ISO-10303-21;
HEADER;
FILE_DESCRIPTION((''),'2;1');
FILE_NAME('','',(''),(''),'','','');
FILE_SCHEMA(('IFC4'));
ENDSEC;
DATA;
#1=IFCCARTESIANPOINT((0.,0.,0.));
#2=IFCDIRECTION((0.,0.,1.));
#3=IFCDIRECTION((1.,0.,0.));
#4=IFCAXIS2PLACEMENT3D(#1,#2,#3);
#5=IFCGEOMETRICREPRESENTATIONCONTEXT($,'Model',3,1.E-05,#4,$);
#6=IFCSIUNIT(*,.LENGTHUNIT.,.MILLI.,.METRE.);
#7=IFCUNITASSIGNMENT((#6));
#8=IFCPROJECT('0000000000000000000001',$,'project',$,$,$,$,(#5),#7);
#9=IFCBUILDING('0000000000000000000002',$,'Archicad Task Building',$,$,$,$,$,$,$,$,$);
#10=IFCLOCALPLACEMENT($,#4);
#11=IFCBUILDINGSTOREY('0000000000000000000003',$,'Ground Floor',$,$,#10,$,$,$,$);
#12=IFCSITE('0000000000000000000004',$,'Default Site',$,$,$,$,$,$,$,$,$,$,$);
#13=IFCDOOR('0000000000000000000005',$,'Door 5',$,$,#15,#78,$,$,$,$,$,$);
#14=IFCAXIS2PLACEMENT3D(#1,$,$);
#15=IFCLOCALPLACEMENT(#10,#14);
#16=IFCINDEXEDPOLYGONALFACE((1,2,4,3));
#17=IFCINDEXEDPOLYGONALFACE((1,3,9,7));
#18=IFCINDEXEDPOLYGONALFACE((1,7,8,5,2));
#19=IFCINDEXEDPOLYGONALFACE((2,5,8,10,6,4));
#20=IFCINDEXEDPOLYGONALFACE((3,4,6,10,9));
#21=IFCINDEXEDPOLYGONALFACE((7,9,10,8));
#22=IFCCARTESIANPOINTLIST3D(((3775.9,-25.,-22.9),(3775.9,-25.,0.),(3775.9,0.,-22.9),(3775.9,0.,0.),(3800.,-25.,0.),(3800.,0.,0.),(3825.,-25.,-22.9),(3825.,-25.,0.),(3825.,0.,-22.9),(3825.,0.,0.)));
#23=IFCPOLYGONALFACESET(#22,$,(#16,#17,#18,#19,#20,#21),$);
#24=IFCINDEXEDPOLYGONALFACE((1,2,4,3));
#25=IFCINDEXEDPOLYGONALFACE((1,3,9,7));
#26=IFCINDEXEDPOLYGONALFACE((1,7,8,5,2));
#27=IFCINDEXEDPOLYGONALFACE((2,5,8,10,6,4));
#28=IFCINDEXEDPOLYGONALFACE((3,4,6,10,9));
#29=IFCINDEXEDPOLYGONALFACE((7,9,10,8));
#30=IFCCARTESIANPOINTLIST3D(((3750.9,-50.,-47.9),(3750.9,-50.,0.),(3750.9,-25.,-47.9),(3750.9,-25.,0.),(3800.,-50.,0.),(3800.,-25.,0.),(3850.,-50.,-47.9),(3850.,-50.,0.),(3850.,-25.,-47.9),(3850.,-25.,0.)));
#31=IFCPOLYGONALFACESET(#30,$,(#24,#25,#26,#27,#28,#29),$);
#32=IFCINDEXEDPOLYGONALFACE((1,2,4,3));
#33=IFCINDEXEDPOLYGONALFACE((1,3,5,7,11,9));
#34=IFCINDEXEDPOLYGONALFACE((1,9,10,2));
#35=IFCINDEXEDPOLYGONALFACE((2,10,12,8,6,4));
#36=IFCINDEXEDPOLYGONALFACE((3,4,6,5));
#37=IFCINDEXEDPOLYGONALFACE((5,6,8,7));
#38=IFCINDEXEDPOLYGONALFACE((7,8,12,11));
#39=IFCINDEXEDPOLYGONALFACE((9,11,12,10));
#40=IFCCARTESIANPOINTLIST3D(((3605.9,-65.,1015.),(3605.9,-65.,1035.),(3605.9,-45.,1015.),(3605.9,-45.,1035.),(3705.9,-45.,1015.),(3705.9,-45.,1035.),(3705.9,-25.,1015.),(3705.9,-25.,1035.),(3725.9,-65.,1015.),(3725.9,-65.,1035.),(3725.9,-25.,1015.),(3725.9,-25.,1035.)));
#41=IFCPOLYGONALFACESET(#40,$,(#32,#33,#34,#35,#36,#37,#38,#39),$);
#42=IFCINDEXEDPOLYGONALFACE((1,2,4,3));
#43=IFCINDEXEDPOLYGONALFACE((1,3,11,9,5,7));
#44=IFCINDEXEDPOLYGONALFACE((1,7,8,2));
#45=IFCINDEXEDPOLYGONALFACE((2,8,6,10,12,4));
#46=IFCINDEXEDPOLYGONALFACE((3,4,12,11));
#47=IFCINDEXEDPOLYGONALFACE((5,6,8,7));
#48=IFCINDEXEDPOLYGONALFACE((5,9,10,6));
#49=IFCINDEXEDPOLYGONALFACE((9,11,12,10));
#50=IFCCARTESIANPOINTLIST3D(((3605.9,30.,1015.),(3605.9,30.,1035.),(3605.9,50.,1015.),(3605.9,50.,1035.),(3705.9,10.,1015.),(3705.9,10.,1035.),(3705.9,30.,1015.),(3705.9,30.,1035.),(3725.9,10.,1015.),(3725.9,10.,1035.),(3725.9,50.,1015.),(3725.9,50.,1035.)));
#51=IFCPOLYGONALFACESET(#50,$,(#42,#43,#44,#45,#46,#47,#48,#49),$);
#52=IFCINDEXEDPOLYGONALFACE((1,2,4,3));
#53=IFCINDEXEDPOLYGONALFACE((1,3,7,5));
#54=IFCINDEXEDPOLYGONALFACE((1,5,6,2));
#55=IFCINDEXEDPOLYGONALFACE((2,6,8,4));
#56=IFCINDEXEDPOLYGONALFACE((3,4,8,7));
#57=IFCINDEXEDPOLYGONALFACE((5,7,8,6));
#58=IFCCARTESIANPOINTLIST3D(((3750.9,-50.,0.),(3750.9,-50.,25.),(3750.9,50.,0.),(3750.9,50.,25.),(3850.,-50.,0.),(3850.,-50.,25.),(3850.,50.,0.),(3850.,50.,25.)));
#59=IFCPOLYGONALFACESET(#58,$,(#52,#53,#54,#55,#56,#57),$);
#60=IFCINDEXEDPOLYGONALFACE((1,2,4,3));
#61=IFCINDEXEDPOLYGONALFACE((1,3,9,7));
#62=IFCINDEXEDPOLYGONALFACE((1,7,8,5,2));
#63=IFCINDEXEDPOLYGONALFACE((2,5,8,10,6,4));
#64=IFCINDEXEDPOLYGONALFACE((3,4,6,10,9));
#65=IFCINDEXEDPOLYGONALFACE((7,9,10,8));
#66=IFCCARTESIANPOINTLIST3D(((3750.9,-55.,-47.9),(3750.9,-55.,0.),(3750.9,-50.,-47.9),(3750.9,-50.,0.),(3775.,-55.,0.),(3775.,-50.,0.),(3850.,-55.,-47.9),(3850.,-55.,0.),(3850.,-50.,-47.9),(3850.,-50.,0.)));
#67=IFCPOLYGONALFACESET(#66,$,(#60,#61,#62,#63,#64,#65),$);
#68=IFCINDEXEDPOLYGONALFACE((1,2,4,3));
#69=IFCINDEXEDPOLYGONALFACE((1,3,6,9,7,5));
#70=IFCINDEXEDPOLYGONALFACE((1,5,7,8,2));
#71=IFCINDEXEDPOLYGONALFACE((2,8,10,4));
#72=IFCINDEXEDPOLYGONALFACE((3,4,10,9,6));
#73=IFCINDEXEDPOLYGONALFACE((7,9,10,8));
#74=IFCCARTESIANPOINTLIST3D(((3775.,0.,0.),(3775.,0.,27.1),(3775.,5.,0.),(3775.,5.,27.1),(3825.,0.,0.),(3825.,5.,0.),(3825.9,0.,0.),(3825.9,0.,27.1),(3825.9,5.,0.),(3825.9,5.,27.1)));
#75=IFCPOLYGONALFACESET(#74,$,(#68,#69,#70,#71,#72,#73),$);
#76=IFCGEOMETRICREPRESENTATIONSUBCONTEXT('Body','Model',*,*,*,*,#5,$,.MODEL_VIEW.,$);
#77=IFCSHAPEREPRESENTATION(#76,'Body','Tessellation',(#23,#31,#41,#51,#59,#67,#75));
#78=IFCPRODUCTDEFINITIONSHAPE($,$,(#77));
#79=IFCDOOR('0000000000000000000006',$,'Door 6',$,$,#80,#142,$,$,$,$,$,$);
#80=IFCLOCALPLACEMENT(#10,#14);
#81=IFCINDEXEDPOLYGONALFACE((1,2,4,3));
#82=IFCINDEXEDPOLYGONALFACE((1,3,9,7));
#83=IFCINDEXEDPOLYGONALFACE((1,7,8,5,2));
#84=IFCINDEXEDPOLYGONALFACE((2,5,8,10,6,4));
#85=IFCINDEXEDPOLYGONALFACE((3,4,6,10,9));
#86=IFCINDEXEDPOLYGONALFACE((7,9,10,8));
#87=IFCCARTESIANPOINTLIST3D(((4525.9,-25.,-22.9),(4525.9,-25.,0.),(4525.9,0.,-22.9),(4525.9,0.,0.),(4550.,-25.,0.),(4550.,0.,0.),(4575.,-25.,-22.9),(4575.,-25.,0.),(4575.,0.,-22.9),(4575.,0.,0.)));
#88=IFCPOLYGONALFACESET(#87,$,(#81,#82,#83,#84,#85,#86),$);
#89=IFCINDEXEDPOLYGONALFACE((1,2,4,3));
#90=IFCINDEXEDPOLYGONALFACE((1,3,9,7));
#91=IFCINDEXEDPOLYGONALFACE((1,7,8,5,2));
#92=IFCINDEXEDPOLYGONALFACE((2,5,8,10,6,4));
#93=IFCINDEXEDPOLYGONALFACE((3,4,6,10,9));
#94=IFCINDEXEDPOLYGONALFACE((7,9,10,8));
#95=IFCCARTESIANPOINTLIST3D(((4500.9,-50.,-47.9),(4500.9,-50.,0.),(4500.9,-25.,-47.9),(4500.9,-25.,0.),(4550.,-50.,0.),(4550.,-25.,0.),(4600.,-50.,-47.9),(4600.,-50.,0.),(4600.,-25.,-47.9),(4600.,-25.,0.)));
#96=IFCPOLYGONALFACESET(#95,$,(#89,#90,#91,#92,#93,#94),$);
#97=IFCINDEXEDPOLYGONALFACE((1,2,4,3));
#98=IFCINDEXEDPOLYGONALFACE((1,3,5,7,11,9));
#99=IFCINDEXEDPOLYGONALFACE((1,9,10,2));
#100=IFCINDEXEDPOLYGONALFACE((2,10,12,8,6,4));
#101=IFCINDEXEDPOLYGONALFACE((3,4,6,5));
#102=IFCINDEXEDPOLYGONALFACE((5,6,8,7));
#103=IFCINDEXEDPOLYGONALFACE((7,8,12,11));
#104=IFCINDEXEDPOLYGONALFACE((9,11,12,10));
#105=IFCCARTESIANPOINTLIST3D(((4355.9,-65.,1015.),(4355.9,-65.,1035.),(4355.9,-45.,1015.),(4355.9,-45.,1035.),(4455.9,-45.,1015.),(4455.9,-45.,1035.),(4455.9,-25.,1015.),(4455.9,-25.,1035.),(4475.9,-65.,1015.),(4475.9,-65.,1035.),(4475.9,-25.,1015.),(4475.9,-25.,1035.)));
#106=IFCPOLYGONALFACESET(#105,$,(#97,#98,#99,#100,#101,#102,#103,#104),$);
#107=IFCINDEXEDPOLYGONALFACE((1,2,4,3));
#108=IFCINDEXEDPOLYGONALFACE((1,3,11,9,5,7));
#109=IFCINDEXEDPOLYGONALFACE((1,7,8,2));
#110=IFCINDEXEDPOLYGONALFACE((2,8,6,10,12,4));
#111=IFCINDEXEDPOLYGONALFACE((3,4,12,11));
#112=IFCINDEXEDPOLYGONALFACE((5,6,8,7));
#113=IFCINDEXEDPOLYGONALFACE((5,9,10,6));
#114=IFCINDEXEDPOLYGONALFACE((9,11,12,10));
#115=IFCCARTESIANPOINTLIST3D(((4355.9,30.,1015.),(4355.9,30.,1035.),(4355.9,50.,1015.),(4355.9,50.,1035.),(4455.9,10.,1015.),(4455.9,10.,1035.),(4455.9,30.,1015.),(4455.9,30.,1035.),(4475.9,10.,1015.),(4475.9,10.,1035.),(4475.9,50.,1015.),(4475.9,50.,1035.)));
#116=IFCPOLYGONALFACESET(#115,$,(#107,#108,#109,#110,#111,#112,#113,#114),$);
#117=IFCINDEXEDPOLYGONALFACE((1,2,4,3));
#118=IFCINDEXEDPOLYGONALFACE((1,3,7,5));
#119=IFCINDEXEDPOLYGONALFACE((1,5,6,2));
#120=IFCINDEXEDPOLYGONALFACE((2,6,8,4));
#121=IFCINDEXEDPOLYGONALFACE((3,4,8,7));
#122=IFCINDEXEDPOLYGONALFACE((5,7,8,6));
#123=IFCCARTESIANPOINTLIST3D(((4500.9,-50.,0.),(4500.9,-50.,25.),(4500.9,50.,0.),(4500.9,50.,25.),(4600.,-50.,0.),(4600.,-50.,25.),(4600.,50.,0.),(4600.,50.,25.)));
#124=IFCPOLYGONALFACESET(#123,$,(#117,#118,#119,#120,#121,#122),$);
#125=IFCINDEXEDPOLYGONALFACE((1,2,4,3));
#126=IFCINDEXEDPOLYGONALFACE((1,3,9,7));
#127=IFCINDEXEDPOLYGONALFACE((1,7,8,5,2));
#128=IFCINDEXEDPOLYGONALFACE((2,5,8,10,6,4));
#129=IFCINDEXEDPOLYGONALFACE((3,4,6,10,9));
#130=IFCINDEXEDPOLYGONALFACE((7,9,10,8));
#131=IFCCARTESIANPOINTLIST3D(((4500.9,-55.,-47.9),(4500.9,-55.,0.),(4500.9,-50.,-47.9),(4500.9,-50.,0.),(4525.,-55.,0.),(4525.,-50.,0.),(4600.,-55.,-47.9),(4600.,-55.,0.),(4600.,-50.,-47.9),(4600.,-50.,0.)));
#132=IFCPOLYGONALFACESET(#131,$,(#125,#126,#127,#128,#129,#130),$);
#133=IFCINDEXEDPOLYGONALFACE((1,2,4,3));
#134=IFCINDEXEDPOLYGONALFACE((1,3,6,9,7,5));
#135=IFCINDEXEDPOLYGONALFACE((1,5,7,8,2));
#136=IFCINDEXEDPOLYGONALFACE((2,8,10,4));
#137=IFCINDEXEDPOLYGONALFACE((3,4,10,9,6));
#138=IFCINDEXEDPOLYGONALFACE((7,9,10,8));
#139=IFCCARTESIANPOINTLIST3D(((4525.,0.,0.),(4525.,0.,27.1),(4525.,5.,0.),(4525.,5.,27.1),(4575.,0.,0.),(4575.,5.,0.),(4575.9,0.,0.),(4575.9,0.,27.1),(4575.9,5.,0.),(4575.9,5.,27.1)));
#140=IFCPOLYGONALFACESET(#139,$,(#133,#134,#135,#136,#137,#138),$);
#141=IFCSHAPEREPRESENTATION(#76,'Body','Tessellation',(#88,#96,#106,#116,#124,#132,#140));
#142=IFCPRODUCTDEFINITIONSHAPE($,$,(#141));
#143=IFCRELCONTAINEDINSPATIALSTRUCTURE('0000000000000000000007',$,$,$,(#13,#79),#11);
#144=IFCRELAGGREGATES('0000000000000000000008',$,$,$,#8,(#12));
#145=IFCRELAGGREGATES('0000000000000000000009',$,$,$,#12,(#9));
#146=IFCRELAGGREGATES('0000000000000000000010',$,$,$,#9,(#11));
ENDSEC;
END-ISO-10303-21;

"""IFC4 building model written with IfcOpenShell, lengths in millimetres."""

from ifc_helpers import new_model, si_unit, frame, origin_with_axes, place, context, subcontext, project, spatial, line, indexed_curve, outline, extrude, element, save


model = new_model("IFC4")

# Units and contexts
model_context = context("Model", 3, precision=1e-05, world=origin_with_axes())
body_context = subcontext(model_context, "Body", "Model", "MODEL_VIEW")
ifc_project = project(units=[si_unit("LENGTHUNIT", "METRE", prefix="MILLI")], contexts=[model_context])

# Site, building, storey
site = spatial("IfcSite", under=ifc_project, Name="Default Site")
building = spatial("IfcBuilding", under=site, Name="Archicad Task Building")
storey_placement = place(None, origin_with_axes())
storey = spatial("IfcBuildingStorey", under=building, at=storey_placement, Name="Ground Floor")

# Doors
door_1_placement = place(storey_placement, frame((3800.0, -50.0, 0.0), z_axis=(0.0, 0.0, 1.0), x_axis=(1.0, 0.0, 0.0)))
element("IfcDoor", 1, at=door_1_placement, inside=storey, Name="Door 5", context=body_context, shape_type="SweptSolid", body=[
    extrude(outline(indexed_curve([(0.0, 0.0), (0.0, 2.1), (0.9, 2.1), (0.9, 0.0), (-24.1, 0.0), (-24.1, -22.9), (25.0, -22.9), (25.0, 0.0)], segments=[line(1, 2, 3, 4, 5, 6, 7, 8, 1)])), frame((0.0, 25.0, 0.0), z_axis=(0.0, -1.0, 0.0), x_axis=(1.0, 0.0, 0.0)), (0.0, 0.0, -1.0), 25.0),
    extrude(outline(indexed_curve([(0.0, 0.0), (0.0, 2.1), (0.9, 2.1), (0.9, 0.0), (-49.1, 0.0), (-49.1, -47.9), (50.0, -47.9), (50.0, 0.0)], segments=[line(1, 2, 3, 4, 5, 6, 7, 8, 1)])), frame((0.0, 0.0, 0.0), z_axis=(0.0, -1.0, 0.0), x_axis=(1.0, 0.0, 0.0)), (0.0, 0.0, -1.0), 25.0),
    extrude(outline(indexed_curve([(0.0, 0.0), (-49.1, 0.0), (-49.1, 35.0), (0.0, 35.0)], segments=[line(1, 2, 3, 4, 1)])), frame((25.0, 25.0, 25.0), z_axis=(0.0, 0.0, 1.0), x_axis=(1.0, 0.0, 0.0)), (0.0, 0.0, 1.0), -47.9),
    extrude(outline(indexed_curve([(0.0, 0.0), (0.0, -40.0), (-120.0, -40.0), (-120.0, -20.0), (-20.0, -20.0), (-20.0, 0.0)], segments=[line(1, 2, 3, 4, 5, 6, 1)])), frame((-74.1, 25.0, 1015.0), z_axis=(0.0, 0.0, 1.0), x_axis=(1.0, 0.0, 0.0)), (0.0, 0.0, 1.0), 20.0),
    extrude(outline(indexed_curve([(0.0, 0.0), (0.0, 40.0), (-120.0, 40.0), (-120.0, 20.0), (-20.0, 20.0), (-20.0, 0.0)], segments=[line(1, 2, 3, 4, 5, 6, 1)])), frame((-74.1, 60.0, 1015.0), z_axis=(0.0, 0.0, 1.0), x_axis=(1.0, 0.0, 0.0)), (0.0, 0.0, 1.0), 20.0),
    extrude(outline(indexed_curve([(0.0, 0.0), (-99.1, 0.0), (-99.1, 100.0), (0.0, 100.0)], segments=[line(1, 2, 3, 4, 1)])), frame((50.0, 0.0, 0.0), z_axis=(0.0, 0.0, 1.0), x_axis=(1.0, 0.0, 0.0)), (0.0, 0.0, 1.0), 25.0),
    extrude(outline(indexed_curve([(0.0, 0.0), (0.0, 27.1), (50.9, 27.1), (50.9, 0.0), (-24.1, 0.0), (-24.1, -47.9), (75.0, -47.9), (75.0, 0.0)], segments=[line(1, 2, 3, 4, 5, 6, 7, 8, 1)])), frame((-25.0, -5.0, 0.0), z_axis=(0.0, -1.0, 0.0), x_axis=(1.0, 0.0, 0.0)), (0.0, 0.0, -1.0), 5.0),
    extrude(outline(indexed_curve([(0.0, 0.0), (0.0, 27.1), (50.9, 27.1), (50.9, 0.0), (0.9, 0.0), (0.9, -22.9), (50.0, -22.9), (50.0, 0.0)], segments=[line(1, 2, 3, 4, 5, 6, 7, 8, 1)])), frame((-25.0, 50.0, 0.0), z_axis=(0.0, -1.0, 0.0), x_axis=(1.0, 0.0, 0.0)), (0.0, 0.0, -1.0), 5.0),
])
door_2_placement = place(storey_placement, frame((4550.0, -50.0, 0.0), z_axis=(0.0, 0.0, 1.0), x_axis=(1.0, 0.0, 0.0)))
element("IfcDoor", 2, at=door_2_placement, inside=storey, Name="Door 6", context=body_context, shape_type="SweptSolid", body=[
    extrude(outline(indexed_curve([(0.0, 0.0), (0.0, 2.1), (0.9, 2.1), (0.9, 0.0), (-24.1, 0.0), (-24.1, -22.9), (25.0, -22.9), (25.0, 0.0)], segments=[line(1, 2, 3, 4, 5, 6, 7, 8, 1)])), frame((0.0, 25.0, 0.0), z_axis=(0.0, -1.0, 0.0), x_axis=(1.0, 0.0, 0.0)), (0.0, 0.0, -1.0), 25.0),
    extrude(outline(indexed_curve([(0.0, 0.0), (0.0, 2.1), (0.9, 2.1), (0.9, 0.0), (-49.1, 0.0), (-49.1, -47.9), (50.0, -47.9), (50.0, 0.0)], segments=[line(1, 2, 3, 4, 5, 6, 7, 8, 1)])), frame((0.0, 0.0, 0.0), z_axis=(0.0, -1.0, 0.0), x_axis=(1.0, 0.0, 0.0)), (0.0, 0.0, -1.0), 25.0),
    extrude(outline(indexed_curve([(0.0, 0.0), (-49.1, 0.0), (-49.1, 35.0), (0.0, 35.0)], segments=[line(1, 2, 3, 4, 1)])), frame((25.0, 25.0, 25.0), z_axis=(0.0, 0.0, 1.0), x_axis=(1.0, 0.0, 0.0)), (0.0, 0.0, 1.0), -47.9),
    extrude(outline(indexed_curve([(0.0, 0.0), (0.0, -40.0), (-120.0, -40.0), (-120.0, -20.0), (-20.0, -20.0), (-20.0, 0.0)], segments=[line(1, 2, 3, 4, 5, 6, 1)])), frame((-74.1, 25.0, 1015.0), z_axis=(0.0, 0.0, 1.0), x_axis=(1.0, 0.0, 0.0)), (0.0, 0.0, 1.0), 20.0),
    extrude(outline(indexed_curve([(0.0, 0.0), (0.0, 40.0), (-120.0, 40.0), (-120.0, 20.0), (-20.0, 20.0), (-20.0, 0.0)], segments=[line(1, 2, 3, 4, 5, 6, 1)])), frame((-74.1, 60.0, 1015.0), z_axis=(0.0, 0.0, 1.0), x_axis=(1.0, 0.0, 0.0)), (0.0, 0.0, 1.0), 20.0),
    extrude(outline(indexed_curve([(0.0, 0.0), (-99.1, 0.0), (-99.1, 100.0), (0.0, 100.0)], segments=[line(1, 2, 3, 4, 1)])), frame((50.0, 0.0, 0.0), z_axis=(0.0, 0.0, 1.0), x_axis=(1.0, 0.0, 0.0)), (0.0, 0.0, 1.0), 25.0),
    extrude(outline(indexed_curve([(0.0, 0.0), (0.0, 27.1), (50.9, 27.1), (50.9, 0.0), (-24.1, 0.0), (-24.1, -47.9), (75.0, -47.9), (75.0, 0.0)], segments=[line(1, 2, 3, 4, 5, 6, 7, 8, 1)])), frame((-25.0, -5.0, 0.0), z_axis=(0.0, -1.0, 0.0), x_axis=(1.0, 0.0, 0.0)), (0.0, 0.0, -1.0), 5.0),
    extrude(outline(indexed_curve([(0.0, 0.0), (0.0, 27.1), (50.9, 27.1), (50.9, 0.0), (0.9, 0.0), (0.9, -22.9), (50.0, -22.9), (50.0, 0.0)], segments=[line(1, 2, 3, 4, 5, 6, 7, 8, 1)])), frame((-25.0, 50.0, 0.0), z_axis=(0.0, -1.0, 0.0), x_axis=(1.0, 0.0, 0.0)), (0.0, 0.0, -1.0), 5.0),
])

save(model, "model.ifc")
